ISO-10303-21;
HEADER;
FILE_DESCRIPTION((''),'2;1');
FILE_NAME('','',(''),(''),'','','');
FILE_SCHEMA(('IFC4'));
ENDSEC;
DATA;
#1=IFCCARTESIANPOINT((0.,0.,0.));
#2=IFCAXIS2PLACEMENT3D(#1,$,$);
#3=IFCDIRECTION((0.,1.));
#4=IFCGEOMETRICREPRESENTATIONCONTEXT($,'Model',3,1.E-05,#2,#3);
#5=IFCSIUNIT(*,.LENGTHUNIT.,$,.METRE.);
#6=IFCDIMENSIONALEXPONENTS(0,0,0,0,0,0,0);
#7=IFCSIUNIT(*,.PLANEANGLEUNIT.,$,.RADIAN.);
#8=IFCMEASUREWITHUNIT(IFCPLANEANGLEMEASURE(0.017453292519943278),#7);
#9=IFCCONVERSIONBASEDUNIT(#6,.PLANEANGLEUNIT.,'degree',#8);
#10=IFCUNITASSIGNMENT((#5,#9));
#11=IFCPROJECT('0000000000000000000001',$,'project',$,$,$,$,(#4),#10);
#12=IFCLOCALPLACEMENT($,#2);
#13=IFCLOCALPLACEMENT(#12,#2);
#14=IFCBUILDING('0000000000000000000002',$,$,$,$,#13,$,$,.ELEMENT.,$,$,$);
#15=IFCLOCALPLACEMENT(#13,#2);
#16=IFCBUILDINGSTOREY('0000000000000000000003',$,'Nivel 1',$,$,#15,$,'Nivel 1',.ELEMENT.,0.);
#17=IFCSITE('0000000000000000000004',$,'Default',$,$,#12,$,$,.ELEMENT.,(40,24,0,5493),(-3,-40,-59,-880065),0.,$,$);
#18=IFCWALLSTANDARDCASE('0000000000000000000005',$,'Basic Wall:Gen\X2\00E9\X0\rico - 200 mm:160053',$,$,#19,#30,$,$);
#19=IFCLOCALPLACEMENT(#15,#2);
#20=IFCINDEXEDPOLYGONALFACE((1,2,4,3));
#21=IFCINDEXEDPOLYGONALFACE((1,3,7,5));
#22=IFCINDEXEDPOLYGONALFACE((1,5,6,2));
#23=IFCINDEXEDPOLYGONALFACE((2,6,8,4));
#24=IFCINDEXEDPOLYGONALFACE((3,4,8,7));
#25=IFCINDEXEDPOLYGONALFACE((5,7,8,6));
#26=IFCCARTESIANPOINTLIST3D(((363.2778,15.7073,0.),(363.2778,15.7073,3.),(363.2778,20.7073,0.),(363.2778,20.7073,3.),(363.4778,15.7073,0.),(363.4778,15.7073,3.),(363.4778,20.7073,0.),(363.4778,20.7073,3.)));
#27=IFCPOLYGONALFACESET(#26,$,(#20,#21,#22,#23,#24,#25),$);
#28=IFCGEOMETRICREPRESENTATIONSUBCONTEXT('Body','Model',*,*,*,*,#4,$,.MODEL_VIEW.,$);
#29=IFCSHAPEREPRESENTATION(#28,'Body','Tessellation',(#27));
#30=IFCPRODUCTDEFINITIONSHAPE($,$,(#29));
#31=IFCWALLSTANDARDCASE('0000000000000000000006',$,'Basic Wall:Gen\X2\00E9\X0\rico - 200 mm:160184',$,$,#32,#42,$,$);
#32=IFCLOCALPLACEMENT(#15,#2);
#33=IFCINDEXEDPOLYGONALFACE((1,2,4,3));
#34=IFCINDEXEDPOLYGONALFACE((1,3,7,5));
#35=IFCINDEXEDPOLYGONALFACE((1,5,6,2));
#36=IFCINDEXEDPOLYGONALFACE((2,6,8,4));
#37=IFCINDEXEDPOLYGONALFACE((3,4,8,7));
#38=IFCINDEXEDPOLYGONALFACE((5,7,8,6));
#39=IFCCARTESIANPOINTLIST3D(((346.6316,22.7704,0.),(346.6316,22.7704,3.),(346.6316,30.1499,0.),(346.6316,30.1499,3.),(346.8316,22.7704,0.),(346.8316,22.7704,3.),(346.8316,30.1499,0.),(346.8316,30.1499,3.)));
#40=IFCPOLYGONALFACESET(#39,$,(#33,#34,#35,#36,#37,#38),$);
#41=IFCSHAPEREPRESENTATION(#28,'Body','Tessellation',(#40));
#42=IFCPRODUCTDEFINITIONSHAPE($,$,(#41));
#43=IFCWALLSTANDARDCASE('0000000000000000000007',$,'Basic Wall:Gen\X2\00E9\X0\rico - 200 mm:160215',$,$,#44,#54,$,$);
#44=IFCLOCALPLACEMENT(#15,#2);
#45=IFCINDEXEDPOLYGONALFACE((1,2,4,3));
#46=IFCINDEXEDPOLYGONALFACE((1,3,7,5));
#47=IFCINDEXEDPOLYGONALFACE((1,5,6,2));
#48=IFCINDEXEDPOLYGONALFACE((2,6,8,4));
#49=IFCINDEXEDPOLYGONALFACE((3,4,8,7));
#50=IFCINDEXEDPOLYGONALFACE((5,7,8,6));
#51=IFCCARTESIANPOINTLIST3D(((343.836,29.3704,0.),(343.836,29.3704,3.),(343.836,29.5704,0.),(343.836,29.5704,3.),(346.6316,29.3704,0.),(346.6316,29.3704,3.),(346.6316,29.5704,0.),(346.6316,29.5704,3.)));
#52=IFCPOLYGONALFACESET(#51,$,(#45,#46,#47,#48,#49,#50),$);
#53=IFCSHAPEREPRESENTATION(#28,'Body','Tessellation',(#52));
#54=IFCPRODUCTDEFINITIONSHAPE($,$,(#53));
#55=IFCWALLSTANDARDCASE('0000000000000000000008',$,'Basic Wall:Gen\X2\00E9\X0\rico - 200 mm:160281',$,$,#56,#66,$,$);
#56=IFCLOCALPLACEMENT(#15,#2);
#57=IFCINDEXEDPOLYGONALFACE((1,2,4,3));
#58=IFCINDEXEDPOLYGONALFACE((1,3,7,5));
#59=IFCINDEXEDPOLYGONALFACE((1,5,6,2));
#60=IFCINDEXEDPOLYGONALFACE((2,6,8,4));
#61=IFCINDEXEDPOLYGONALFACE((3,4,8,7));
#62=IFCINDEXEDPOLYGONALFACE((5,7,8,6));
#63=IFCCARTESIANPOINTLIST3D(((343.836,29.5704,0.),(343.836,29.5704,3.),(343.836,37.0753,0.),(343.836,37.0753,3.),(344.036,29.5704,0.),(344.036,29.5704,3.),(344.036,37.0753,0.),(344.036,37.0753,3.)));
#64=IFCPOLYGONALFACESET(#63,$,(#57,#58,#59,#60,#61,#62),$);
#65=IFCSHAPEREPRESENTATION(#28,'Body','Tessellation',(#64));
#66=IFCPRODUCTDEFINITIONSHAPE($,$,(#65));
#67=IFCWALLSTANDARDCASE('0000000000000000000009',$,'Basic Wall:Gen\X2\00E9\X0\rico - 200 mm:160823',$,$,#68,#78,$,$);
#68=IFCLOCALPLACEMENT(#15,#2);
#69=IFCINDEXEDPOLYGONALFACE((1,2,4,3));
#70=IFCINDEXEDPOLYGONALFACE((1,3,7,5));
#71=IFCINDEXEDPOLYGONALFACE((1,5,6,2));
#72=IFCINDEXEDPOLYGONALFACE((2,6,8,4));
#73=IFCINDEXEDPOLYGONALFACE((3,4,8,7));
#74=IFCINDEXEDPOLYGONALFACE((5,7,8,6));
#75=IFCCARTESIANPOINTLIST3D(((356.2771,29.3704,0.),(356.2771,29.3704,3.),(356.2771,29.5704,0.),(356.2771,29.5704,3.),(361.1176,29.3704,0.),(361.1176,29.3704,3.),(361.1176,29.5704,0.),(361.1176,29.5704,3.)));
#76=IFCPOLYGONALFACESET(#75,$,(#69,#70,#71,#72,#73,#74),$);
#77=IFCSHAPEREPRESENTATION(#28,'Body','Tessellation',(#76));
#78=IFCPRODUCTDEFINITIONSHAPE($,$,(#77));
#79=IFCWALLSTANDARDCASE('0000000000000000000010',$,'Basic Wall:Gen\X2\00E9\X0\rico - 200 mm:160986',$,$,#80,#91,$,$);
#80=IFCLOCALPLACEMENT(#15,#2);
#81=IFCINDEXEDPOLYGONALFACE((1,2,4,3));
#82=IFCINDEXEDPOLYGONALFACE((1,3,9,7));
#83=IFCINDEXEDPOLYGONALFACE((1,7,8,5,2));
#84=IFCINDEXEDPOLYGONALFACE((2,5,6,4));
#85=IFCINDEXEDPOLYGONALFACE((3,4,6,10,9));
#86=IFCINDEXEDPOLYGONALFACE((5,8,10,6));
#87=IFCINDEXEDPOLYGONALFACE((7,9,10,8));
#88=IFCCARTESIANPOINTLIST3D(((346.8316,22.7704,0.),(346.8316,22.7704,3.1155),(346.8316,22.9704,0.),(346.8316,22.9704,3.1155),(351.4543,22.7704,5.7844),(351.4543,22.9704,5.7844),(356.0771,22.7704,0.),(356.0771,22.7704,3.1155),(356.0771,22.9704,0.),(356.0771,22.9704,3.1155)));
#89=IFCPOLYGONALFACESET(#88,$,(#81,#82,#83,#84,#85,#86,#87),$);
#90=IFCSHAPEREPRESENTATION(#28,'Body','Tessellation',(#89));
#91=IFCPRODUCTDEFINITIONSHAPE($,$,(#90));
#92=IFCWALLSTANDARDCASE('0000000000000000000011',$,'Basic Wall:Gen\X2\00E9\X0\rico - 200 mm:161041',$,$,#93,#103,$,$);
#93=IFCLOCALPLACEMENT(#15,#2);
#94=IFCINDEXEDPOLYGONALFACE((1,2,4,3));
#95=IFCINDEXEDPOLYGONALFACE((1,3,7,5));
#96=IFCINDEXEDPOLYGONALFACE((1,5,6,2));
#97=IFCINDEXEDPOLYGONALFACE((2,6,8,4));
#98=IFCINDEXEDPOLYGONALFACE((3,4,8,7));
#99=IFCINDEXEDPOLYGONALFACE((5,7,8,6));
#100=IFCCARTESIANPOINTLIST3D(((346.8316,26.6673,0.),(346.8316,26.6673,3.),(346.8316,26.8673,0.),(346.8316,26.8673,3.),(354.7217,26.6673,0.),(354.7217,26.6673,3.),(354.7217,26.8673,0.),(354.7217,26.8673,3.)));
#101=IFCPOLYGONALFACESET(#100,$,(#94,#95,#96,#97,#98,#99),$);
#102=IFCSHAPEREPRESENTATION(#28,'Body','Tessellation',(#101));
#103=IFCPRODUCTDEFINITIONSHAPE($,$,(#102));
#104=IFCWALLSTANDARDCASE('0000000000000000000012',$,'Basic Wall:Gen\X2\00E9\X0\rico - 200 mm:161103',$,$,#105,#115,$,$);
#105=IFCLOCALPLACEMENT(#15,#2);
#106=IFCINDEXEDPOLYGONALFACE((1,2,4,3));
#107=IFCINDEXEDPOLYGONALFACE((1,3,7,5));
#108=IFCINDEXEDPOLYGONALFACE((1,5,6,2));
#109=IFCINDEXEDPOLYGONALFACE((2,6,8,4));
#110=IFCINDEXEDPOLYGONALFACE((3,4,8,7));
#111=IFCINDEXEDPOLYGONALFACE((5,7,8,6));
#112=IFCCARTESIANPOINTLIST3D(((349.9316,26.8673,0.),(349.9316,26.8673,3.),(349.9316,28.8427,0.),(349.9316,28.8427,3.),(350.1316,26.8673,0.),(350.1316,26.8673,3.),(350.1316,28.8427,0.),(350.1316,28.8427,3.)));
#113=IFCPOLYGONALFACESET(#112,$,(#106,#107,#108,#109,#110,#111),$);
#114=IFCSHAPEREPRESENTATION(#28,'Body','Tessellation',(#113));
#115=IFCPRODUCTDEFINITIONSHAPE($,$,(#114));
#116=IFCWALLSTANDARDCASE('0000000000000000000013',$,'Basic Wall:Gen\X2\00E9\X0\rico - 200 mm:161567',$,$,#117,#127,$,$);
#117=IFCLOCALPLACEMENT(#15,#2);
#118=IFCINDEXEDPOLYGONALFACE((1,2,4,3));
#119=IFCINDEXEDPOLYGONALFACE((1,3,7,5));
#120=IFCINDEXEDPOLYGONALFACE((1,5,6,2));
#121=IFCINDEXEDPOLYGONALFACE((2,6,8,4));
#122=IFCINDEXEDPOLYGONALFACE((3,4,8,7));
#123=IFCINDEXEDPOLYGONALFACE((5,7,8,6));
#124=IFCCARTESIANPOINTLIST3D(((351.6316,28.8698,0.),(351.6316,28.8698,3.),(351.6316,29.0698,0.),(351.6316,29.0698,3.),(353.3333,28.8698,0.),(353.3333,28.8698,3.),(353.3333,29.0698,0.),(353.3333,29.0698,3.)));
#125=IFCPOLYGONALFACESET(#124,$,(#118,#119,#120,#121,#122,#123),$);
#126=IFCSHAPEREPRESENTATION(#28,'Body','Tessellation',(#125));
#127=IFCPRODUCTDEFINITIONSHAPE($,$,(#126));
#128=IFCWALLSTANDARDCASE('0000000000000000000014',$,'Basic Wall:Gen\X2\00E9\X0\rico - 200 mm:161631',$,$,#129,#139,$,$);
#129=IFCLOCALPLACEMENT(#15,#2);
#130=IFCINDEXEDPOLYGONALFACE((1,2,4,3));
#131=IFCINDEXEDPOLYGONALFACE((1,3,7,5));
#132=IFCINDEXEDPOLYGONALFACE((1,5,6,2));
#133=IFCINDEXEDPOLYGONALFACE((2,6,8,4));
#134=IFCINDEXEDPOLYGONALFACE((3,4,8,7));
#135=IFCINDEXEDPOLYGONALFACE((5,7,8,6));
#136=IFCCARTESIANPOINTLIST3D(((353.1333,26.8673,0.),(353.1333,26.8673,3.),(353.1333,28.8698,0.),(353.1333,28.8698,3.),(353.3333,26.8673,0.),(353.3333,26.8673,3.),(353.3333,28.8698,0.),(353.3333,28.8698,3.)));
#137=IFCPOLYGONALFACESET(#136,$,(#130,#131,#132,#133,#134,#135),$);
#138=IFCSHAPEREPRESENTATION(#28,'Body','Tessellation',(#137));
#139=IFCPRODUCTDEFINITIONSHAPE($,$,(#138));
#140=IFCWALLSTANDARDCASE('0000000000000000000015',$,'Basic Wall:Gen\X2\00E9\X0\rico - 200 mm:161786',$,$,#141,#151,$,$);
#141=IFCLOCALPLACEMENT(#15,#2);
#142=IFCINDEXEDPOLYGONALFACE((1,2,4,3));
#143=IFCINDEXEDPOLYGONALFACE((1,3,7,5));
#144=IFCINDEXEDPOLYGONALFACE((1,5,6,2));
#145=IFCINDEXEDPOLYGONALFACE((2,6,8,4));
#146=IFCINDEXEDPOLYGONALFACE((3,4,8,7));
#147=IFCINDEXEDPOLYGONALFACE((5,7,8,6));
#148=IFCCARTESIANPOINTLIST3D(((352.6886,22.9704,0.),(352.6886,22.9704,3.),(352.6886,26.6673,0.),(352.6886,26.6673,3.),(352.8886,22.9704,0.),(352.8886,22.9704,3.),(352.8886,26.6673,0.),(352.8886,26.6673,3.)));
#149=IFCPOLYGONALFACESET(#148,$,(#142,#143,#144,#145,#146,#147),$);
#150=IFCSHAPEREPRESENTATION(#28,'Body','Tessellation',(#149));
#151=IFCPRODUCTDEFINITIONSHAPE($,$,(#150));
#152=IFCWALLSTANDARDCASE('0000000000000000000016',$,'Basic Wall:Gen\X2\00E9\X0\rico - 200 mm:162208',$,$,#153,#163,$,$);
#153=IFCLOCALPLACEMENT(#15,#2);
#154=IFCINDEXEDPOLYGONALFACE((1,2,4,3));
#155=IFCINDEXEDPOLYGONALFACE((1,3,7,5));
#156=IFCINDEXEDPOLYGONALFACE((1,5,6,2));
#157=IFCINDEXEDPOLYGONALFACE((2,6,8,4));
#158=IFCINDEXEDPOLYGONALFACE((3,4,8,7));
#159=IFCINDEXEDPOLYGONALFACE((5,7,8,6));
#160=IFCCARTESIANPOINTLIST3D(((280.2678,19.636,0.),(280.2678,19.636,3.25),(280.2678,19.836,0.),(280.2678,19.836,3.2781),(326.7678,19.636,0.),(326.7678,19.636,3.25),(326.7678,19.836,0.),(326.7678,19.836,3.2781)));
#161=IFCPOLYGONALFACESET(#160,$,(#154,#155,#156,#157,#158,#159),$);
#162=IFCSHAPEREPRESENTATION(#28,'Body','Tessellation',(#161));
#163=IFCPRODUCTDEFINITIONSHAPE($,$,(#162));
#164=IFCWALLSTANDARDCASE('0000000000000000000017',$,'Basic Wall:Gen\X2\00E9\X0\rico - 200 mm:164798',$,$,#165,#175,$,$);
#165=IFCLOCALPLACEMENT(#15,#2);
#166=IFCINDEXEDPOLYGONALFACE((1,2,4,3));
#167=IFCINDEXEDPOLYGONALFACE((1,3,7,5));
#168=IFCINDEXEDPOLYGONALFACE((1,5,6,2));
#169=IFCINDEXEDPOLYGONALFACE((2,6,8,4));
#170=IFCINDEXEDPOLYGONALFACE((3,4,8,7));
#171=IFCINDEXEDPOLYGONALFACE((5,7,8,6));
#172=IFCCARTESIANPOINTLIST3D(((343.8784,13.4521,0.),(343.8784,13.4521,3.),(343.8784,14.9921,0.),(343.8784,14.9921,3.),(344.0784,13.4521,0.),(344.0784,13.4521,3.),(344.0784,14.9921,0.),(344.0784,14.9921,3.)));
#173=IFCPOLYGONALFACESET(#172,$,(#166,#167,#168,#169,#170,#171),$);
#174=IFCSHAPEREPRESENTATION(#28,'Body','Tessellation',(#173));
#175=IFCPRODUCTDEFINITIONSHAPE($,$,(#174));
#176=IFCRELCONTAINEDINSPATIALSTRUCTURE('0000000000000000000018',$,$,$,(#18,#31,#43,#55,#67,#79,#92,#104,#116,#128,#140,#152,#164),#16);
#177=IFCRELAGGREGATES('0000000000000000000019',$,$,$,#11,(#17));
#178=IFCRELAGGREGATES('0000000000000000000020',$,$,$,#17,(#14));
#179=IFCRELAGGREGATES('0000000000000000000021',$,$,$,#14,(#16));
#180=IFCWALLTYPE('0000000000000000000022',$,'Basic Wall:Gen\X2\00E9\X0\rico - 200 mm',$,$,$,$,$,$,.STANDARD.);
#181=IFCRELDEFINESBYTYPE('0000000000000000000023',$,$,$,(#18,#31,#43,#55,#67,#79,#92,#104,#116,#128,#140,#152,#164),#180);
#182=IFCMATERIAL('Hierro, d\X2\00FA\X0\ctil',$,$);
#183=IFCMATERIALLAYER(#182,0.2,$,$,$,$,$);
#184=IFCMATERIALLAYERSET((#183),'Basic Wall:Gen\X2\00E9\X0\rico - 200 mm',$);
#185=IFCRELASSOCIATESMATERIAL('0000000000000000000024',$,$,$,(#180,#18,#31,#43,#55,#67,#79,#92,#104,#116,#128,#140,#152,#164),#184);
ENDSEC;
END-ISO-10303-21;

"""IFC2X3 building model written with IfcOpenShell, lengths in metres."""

from ifc_helpers import new_model, entity, si_unit, converted_unit, direction, frame, frame_2d, origin, place, context, subcontext, project, spatial, polyline, rectangle, extrude, clip, bounded_halfspace, material, layer, layer_set, layer_usage, type_object, element, save


model = new_model("IFC2X3")

# Units and contexts
model_context = context("Model", 3, precision=1e-05, world=origin(), true_north=direction((0.0, 1.0)))
body_context = subcontext(model_context, "Body", "Model", "MODEL_VIEW")
ifc_project = project(units=[si_unit("LENGTHUNIT", "METRE"), converted_unit("PLANEANGLEUNIT", "degree", entity("IfcPlaneAngleMeasure", 0.017453292519943278), si_unit("PLANEANGLEUNIT", "RADIAN"), dimensions=[0, 0, 0, 0, 0, 0, 0])], contexts=[model_context])

# Site, building, storey
site_placement = place(None, origin())
site = spatial("IfcSite", under=ifc_project, at=site_placement, Name="Default", CompositionType="ELEMENT", RefLatitude=(40, 24, 0, 5493), RefLongitude=(-3, -40, -59, -880065), RefElevation=0.0)
building_placement = place(site_placement, origin())
building = spatial("IfcBuilding", under=site, at=building_placement, CompositionType="ELEMENT")
storey_placement = place(building_placement, origin())
storey = spatial("IfcBuildingStorey", under=building, at=storey_placement, Name="Nivel 1", LongName="Nivel 1", CompositionType="ELEMENT", Elevation=0.0)

# Walls
ifc_material_1 = material(Name="Hierro, dúctil")
ifc_layer_1 = layer(ifc_material_1, 0.2)
ifc_layer_set_1 = layer_set([ifc_layer_1], Name="Basic Wall:Genérico - 200 mm")
wall_type = type_object("IfcWallType", Name="Basic Wall:Genérico - 200 mm", PredefinedType="STANDARD", material=ifc_layer_set_1)
ifc_layer_usage_1 = layer_usage(ifc_layer_set_1, "AXIS2", "NEGATIVE", 0.1)
wall_1_placement = place(storey_placement, frame((363.3778, 20.7073, 0.0), z_axis=(0.0, 0.0, 1.0), x_axis=(0.0, -1.0, 0.0)))
element("IfcWallStandardCase", 1, at=wall_1_placement, inside=storey, type_object=wall_type, material=ifc_layer_usage_1, Name="Basic Wall:Genérico - 200 mm:160053", context=body_context, shape_type="SweptSolid", body=[
    extrude(rectangle(XDim=5.0, YDim=0.2, at=frame_2d((2.5, 0.0), x_axis=(-1.0, 0.0))), origin(), (0.0, 0.0, 1.0), 3.0),
])
ifc_layer_usage_2 = layer_usage(ifc_layer_set_1, "AXIS2", "NEGATIVE", 0.1)
wall_2_placement = place(storey_placement, frame((346.7316, 22.7704, 0.0), z_axis=(0.0, 0.0, 1.0), x_axis=(0.0, 1.0, 0.0)))
element("IfcWallStandardCase", 2, at=wall_2_placement, inside=storey, type_object=wall_type, material=ifc_layer_usage_2, Name="Basic Wall:Genérico - 200 mm:160184", context=body_context, shape_type="SweptSolid", body=[
    extrude(rectangle(XDim=7.3795, YDim=0.2, at=frame_2d((3.6897, 0.0), x_axis=(-1.0, 0.0))), origin(), (0.0, 0.0, 1.0), 3.0),
])
ifc_layer_usage_3 = layer_usage(ifc_layer_set_1, "AXIS2", "NEGATIVE", 0.1)
wall_3_placement = place(storey_placement, frame((346.6316, 29.4704, 0.0), z_axis=(0.0, 0.0, 1.0), x_axis=(-1.0, 0.0, 0.0)))
element("IfcWallStandardCase", 3, at=wall_3_placement, inside=storey, type_object=wall_type, material=ifc_layer_usage_3, Name="Basic Wall:Genérico - 200 mm:160215", context=body_context, shape_type="SweptSolid", body=[
    extrude(rectangle(XDim=2.7956, YDim=0.2, at=frame_2d((1.3978, 0.0), x_axis=(-1.0, 0.0))), origin(), (0.0, 0.0, 1.0), 3.0),
])
ifc_layer_usage_4 = layer_usage(ifc_layer_set_1, "AXIS2", "NEGATIVE", 0.1)
wall_4_placement = place(storey_placement, frame((343.936, 29.5704, 0.0), z_axis=(0.0, 0.0, 1.0), x_axis=(0.0, 1.0, 0.0)))
element("IfcWallStandardCase", 4, at=wall_4_placement, inside=storey, type_object=wall_type, material=ifc_layer_usage_4, Name="Basic Wall:Genérico - 200 mm:160281", context=body_context, shape_type="SweptSolid", body=[
    extrude(rectangle(XDim=7.5048, YDim=0.2, at=frame_2d((3.7524, 0.0), x_axis=(-1.0, 0.0))), origin(), (0.0, 0.0, 1.0), 3.0),
])
ifc_layer_usage_5 = layer_usage(ifc_layer_set_1, "AXIS2", "NEGATIVE", 0.1)
wall_5_placement = place(storey_placement, frame((361.1176, 29.4704, 0.0), z_axis=(0.0, 0.0, 1.0), x_axis=(-1.0, 0.0, 0.0)))
element("IfcWallStandardCase", 5, at=wall_5_placement, inside=storey, type_object=wall_type, material=ifc_layer_usage_5, Name="Basic Wall:Genérico - 200 mm:160823", context=body_context, shape_type="SweptSolid", body=[
    extrude(rectangle(XDim=4.8405, YDim=0.2, at=frame_2d((2.4202, 0.0), x_axis=(-1.0, 0.0))), origin(), (0.0, 0.0, 1.0), 3.0),
])
ifc_layer_usage_6 = layer_usage(ifc_layer_set_1, "AXIS2", "NEGATIVE", 0.1)
wall_6_placement = place(storey_placement, frame((356.0771, 22.8704, 0.0), z_axis=(0.0, 0.0, 1.0), x_axis=(-1.0, 0.0, 0.0)))
element("IfcWallStandardCase", 6, at=wall_6_placement, inside=storey, type_object=wall_type, material=ifc_layer_usage_6, Name="Basic Wall:Genérico - 200 mm:160986", context=body_context, shape_type="Clipping", body=[
    clip(clip(extrude(rectangle(XDim=9.2456, YDim=0.2, at=frame_2d((4.6228, 0.0), x_axis=(-1.0, 0.0))), origin(), (0.0, 0.0, 1.0), 5.7844), bounded_halfspace(frame((0.0, -0.1, 3.1155), z_axis=(-0.5, 0.0, 0.866025), x_axis=(0.0, -1.0, 0.0)), False, frame((0.0, -0.1, 3.1155)), polyline([(0.0, 0.0), (4.6228, 0.0), (4.6228, 0.2), (0.0, 0.2), (0.0, 0.0)]))), bounded_halfspace(frame((4.6228, -0.1, 5.7844), z_axis=(0.5, 0.0, 0.866025), x_axis=(0.0, 1.0, 0.0)), False, frame((4.6228, -0.1, 5.7844)), polyline([(0.0, 0.0), (4.6228, 0.0), (4.6228, 0.2), (0.0, 0.2), (0.0, 0.0)]))),
])
ifc_layer_usage_7 = layer_usage(ifc_layer_set_1, "AXIS2", "NEGATIVE", 0.1)
wall_7_placement = place(storey_placement, frame((346.8316, 26.7673, 0.0)))
element("IfcWallStandardCase", 7, at=wall_7_placement, inside=storey, type_object=wall_type, material=ifc_layer_usage_7, Name="Basic Wall:Genérico - 200 mm:161041", context=body_context, shape_type="SweptSolid", body=[
    extrude(rectangle(XDim=7.8902, YDim=0.2, at=frame_2d((3.9451, 0.0), x_axis=(-1.0, 0.0))), origin(), (0.0, 0.0, 1.0), 3.0),
])
ifc_layer_usage_8 = layer_usage(ifc_layer_set_1, "AXIS2", "NEGATIVE", 0.1)
wall_8_placement = place(storey_placement, frame((350.0316, 26.8673, 0.0), z_axis=(0.0, 0.0, 1.0), x_axis=(0.0, 1.0, 0.0)))
element("IfcWallStandardCase", 8, at=wall_8_placement, inside=storey, type_object=wall_type, material=ifc_layer_usage_8, Name="Basic Wall:Genérico - 200 mm:161103", context=body_context, shape_type="SweptSolid", body=[
    extrude(rectangle(XDim=1.9755, YDim=0.2, at=frame_2d((0.9877, 0.0), x_axis=(-1.0, 0.0))), origin(), (0.0, 0.0, 1.0), 3.0),
])
ifc_layer_usage_9 = layer_usage(ifc_layer_set_1, "AXIS2", "NEGATIVE", 0.1)
wall_9_placement = place(storey_placement, frame((351.6316, 28.9698, 0.0)))
element("IfcWallStandardCase", 9, at=wall_9_placement, inside=storey, type_object=wall_type, material=ifc_layer_usage_9, Name="Basic Wall:Genérico - 200 mm:161567", context=body_context, shape_type="SweptSolid", body=[
    extrude(rectangle(XDim=1.7018, YDim=0.2, at=frame_2d((0.8509, 0.0), x_axis=(-1.0, 0.0))), origin(), (0.0, 0.0, 1.0), 3.0),
])
ifc_layer_usage_10 = layer_usage(ifc_layer_set_1, "AXIS2", "NEGATIVE", 0.1)
wall_10_placement = place(storey_placement, frame((353.2333, 28.8698, 0.0), z_axis=(0.0, 0.0, 1.0), x_axis=(0.0, -1.0, 0.0)))
element("IfcWallStandardCase", 10, at=wall_10_placement, inside=storey, type_object=wall_type, material=ifc_layer_usage_10, Name="Basic Wall:Genérico - 200 mm:161631", context=body_context, shape_type="SweptSolid", body=[
    extrude(rectangle(XDim=2.0026, YDim=0.2, at=frame_2d((1.0013, 0.0), x_axis=(-1.0, 0.0))), origin(), (0.0, 0.0, 1.0), 3.0),
])
ifc_layer_usage_11 = layer_usage(ifc_layer_set_1, "AXIS2", "NEGATIVE", 0.1)
wall_11_placement = place(storey_placement, frame((352.7886, 22.9704, 0.0), z_axis=(0.0, 0.0, 1.0), x_axis=(0.0, 1.0, 0.0)))
element("IfcWallStandardCase", 11, at=wall_11_placement, inside=storey, type_object=wall_type, material=ifc_layer_usage_11, Name="Basic Wall:Genérico - 200 mm:161786", context=body_context, shape_type="SweptSolid", body=[
    extrude(rectangle(XDim=3.6968, YDim=0.2, at=frame_2d((1.8484, 0.0), x_axis=(-1.0, 0.0))), origin(), (0.0, 0.0, 1.0), 3.0),
])
ifc_layer_usage_12 = layer_usage(ifc_layer_set_1, "AXIS2", "NEGATIVE", 0.1)
wall_12_placement = place(storey_placement, frame((326.7678, 19.736, 0.0), z_axis=(0.0, 0.0, 1.0), x_axis=(-1.0, 0.0, 0.0)))
element("IfcWallStandardCase", 12, at=wall_12_placement, inside=storey, type_object=wall_type, material=ifc_layer_usage_12, Name="Basic Wall:Genérico - 200 mm:162208", context=body_context, shape_type="Clipping", body=[
    clip(extrude(rectangle(XDim=46.5, YDim=0.2, at=frame_2d((23.25, 0.0), x_axis=(-1.0, 0.0))), origin(), (0.0, 0.0, 1.0), 3.2781), bounded_halfspace(frame((0.0, -0.1, 3.2781), z_axis=(0.0, 0.139173, 0.990268), x_axis=(-1.0, 0.0, 0.0)), False, frame((0.0, -0.1, 3.2781)), polyline([(0.0, 0.0), (46.5, 0.0), (46.5, 0.2), (0.0, 0.2), (0.0, 0.0)]))),
])
ifc_layer_usage_13 = layer_usage(ifc_layer_set_1, "AXIS2", "NEGATIVE", 0.1)
wall_13_placement = place(storey_placement, frame((343.9784, 14.9921, 0.0), z_axis=(0.0, 0.0, 1.0), x_axis=(0.0, -1.0, 0.0)))
element("IfcWallStandardCase", 13, at=wall_13_placement, inside=storey, type_object=wall_type, material=ifc_layer_usage_13, Name="Basic Wall:Genérico - 200 mm:164798", context=body_context, shape_type="SweptSolid", body=[
    extrude(rectangle(XDim=1.54, YDim=0.2, at=frame_2d((0.77, 0.0), x_axis=(-1.0, 0.0))), origin(), (0.0, 0.0, 1.0), 3.0),
])

save(model, "model.ifc")
